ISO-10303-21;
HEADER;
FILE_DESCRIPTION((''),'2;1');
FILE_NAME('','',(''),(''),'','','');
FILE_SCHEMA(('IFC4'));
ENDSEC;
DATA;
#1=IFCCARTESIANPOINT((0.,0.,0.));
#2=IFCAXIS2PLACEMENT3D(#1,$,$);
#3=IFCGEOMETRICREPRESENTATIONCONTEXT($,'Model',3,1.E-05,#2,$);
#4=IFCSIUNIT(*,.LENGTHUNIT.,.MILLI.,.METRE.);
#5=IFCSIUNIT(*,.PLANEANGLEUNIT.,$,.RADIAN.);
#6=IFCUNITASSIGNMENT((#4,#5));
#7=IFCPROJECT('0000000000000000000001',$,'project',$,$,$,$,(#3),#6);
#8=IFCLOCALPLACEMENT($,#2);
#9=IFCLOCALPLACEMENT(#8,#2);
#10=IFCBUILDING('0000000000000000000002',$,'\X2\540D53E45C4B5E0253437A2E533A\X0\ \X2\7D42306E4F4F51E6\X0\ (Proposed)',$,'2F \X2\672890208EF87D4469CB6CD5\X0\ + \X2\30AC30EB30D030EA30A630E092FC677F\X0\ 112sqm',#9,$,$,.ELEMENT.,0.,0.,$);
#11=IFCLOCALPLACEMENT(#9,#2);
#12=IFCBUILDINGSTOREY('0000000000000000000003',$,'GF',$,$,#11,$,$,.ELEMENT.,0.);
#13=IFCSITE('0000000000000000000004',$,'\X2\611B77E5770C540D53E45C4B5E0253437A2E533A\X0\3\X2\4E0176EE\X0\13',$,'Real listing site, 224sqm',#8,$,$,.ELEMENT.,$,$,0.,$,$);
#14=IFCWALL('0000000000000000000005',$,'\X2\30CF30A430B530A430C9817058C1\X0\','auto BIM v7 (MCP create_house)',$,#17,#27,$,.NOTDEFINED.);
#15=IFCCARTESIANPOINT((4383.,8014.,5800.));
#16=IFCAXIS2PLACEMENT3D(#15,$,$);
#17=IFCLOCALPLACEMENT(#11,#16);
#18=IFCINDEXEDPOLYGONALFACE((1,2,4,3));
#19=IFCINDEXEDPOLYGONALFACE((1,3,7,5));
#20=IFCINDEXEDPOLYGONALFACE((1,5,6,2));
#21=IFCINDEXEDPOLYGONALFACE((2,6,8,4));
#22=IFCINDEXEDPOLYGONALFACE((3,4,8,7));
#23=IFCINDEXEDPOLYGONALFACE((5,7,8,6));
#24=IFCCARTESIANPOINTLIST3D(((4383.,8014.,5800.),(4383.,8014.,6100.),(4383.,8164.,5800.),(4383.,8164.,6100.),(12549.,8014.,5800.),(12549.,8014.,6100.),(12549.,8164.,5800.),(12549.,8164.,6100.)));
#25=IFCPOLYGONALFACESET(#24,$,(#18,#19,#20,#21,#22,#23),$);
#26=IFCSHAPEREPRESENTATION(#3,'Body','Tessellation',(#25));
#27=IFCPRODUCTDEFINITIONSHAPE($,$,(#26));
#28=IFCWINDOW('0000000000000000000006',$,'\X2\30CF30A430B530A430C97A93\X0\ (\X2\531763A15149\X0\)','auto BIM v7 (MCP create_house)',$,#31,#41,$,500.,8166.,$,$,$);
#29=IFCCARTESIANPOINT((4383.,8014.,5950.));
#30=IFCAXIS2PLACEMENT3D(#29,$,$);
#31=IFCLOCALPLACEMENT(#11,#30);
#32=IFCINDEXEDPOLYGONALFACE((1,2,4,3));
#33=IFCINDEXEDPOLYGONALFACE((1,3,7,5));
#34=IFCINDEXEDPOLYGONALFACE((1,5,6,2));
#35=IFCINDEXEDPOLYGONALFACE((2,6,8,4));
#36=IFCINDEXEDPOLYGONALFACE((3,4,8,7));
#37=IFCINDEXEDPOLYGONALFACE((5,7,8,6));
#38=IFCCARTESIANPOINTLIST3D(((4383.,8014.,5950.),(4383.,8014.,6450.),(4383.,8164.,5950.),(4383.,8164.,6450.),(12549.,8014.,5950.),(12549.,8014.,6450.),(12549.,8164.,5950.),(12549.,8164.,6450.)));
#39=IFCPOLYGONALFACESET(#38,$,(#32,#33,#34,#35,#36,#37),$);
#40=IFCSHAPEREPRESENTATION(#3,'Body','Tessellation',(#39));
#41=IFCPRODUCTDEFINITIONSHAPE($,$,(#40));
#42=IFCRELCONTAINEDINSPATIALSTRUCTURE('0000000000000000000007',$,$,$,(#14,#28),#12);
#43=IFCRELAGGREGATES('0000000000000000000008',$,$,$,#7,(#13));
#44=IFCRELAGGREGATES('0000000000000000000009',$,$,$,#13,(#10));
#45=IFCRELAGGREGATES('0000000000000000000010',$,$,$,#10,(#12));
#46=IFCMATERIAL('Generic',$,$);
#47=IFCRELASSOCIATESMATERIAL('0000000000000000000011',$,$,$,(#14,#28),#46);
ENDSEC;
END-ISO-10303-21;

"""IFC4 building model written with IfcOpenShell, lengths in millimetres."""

from ifc_helpers import new_model, si_unit, frame, frame_2d, origin, place, context, project, spatial, rectangle, extrude, material, element, fill, save


model = new_model("IFC4")

# Units and contexts
model_context = context("Model", 3, precision=1e-05, world=origin())
ifc_project = project(units=[si_unit("LENGTHUNIT", "METRE", prefix="MILLI"), si_unit("PLANEANGLEUNIT", "RADIAN")], contexts=[model_context])

# Site, building, storey
site_placement = place(None, origin())
site = spatial("IfcSite", under=ifc_project, at=site_placement, Name="愛知県名古屋市千種区3丁目13", ObjectType="Real listing site, 224sqm", CompositionType="ELEMENT", RefElevation=0.0)
building_placement = place(site_placement, origin())
building = spatial("IfcBuilding", under=site, at=building_placement, Name="名古屋市千種区 終の住処 (Proposed)", ObjectType="2F 木造軸組構法 + ガルバリウム鋼板 112sqm", CompositionType="ELEMENT", ElevationOfRefHeight=0.0, ElevationOfTerrain=0.0)
storey_placement = place(building_placement, origin())
storey = spatial("IfcBuildingStorey", under=building, at=storey_placement, Name="GF", CompositionType="ELEMENT", Elevation=0.0)

# Shared definitions
ifc_material = material(Name="Generic")

# Wall, opening, window
wall_1_placement = place(storey_placement, frame((4383.0, 8014.0, 5800.0)))
wall_1 = element("IfcWall", 1, at=wall_1_placement, inside=storey, material=ifc_material, Name="ハイサイド腰壁", Description="auto BIM v7 (MCP create_house)", PredefinedType="NOTDEFINED", context=model_context, shape_type="SweptSolid", body=[
    extrude(rectangle(XDim=8166.0, YDim=150.0, at=frame_2d((4083.0, 75.0))), frame((4383.0, 8014.0, 5800.0)), (0.0, 0.0, 1.0), 700.0),
])
opening_1_placement = place(storey_placement, frame((4383.0, 8014.0, 5950.0)))
opening_1 = element("IfcOpeningElement", 2, at=opening_1_placement, cuts=wall_1, PredefinedType="NOTDEFINED", context=model_context, shape_type="SweptSolid", body=[
    extrude(rectangle(XDim=8166.0, YDim=150.0, at=frame_2d((4083.0, 75.0))), frame((4383.0, 8014.0, 5950.0)), (0.0, 0.0, 1.0), 500.0),
])
window_1_placement = place(storey_placement, frame((4383.0, 8014.0, 5950.0)))
window_1 = element("IfcWindow", 3, at=window_1_placement, inside=storey, material=ifc_material, Name="ハイサイド窓 (北採光)", Description="auto BIM v7 (MCP create_house)", OverallHeight=500.0, OverallWidth=8166.0, context=model_context, shape_type="SweptSolid", body=[
    extrude(rectangle(XDim=8166.0, YDim=150.0, at=frame_2d((4083.0, 75.0))), frame((4383.0, 8014.0, 5950.0)), (0.0, 0.0, 1.0), 500.0),
])
fill(opening_1, window_1)

save(model, "model.ifc")
